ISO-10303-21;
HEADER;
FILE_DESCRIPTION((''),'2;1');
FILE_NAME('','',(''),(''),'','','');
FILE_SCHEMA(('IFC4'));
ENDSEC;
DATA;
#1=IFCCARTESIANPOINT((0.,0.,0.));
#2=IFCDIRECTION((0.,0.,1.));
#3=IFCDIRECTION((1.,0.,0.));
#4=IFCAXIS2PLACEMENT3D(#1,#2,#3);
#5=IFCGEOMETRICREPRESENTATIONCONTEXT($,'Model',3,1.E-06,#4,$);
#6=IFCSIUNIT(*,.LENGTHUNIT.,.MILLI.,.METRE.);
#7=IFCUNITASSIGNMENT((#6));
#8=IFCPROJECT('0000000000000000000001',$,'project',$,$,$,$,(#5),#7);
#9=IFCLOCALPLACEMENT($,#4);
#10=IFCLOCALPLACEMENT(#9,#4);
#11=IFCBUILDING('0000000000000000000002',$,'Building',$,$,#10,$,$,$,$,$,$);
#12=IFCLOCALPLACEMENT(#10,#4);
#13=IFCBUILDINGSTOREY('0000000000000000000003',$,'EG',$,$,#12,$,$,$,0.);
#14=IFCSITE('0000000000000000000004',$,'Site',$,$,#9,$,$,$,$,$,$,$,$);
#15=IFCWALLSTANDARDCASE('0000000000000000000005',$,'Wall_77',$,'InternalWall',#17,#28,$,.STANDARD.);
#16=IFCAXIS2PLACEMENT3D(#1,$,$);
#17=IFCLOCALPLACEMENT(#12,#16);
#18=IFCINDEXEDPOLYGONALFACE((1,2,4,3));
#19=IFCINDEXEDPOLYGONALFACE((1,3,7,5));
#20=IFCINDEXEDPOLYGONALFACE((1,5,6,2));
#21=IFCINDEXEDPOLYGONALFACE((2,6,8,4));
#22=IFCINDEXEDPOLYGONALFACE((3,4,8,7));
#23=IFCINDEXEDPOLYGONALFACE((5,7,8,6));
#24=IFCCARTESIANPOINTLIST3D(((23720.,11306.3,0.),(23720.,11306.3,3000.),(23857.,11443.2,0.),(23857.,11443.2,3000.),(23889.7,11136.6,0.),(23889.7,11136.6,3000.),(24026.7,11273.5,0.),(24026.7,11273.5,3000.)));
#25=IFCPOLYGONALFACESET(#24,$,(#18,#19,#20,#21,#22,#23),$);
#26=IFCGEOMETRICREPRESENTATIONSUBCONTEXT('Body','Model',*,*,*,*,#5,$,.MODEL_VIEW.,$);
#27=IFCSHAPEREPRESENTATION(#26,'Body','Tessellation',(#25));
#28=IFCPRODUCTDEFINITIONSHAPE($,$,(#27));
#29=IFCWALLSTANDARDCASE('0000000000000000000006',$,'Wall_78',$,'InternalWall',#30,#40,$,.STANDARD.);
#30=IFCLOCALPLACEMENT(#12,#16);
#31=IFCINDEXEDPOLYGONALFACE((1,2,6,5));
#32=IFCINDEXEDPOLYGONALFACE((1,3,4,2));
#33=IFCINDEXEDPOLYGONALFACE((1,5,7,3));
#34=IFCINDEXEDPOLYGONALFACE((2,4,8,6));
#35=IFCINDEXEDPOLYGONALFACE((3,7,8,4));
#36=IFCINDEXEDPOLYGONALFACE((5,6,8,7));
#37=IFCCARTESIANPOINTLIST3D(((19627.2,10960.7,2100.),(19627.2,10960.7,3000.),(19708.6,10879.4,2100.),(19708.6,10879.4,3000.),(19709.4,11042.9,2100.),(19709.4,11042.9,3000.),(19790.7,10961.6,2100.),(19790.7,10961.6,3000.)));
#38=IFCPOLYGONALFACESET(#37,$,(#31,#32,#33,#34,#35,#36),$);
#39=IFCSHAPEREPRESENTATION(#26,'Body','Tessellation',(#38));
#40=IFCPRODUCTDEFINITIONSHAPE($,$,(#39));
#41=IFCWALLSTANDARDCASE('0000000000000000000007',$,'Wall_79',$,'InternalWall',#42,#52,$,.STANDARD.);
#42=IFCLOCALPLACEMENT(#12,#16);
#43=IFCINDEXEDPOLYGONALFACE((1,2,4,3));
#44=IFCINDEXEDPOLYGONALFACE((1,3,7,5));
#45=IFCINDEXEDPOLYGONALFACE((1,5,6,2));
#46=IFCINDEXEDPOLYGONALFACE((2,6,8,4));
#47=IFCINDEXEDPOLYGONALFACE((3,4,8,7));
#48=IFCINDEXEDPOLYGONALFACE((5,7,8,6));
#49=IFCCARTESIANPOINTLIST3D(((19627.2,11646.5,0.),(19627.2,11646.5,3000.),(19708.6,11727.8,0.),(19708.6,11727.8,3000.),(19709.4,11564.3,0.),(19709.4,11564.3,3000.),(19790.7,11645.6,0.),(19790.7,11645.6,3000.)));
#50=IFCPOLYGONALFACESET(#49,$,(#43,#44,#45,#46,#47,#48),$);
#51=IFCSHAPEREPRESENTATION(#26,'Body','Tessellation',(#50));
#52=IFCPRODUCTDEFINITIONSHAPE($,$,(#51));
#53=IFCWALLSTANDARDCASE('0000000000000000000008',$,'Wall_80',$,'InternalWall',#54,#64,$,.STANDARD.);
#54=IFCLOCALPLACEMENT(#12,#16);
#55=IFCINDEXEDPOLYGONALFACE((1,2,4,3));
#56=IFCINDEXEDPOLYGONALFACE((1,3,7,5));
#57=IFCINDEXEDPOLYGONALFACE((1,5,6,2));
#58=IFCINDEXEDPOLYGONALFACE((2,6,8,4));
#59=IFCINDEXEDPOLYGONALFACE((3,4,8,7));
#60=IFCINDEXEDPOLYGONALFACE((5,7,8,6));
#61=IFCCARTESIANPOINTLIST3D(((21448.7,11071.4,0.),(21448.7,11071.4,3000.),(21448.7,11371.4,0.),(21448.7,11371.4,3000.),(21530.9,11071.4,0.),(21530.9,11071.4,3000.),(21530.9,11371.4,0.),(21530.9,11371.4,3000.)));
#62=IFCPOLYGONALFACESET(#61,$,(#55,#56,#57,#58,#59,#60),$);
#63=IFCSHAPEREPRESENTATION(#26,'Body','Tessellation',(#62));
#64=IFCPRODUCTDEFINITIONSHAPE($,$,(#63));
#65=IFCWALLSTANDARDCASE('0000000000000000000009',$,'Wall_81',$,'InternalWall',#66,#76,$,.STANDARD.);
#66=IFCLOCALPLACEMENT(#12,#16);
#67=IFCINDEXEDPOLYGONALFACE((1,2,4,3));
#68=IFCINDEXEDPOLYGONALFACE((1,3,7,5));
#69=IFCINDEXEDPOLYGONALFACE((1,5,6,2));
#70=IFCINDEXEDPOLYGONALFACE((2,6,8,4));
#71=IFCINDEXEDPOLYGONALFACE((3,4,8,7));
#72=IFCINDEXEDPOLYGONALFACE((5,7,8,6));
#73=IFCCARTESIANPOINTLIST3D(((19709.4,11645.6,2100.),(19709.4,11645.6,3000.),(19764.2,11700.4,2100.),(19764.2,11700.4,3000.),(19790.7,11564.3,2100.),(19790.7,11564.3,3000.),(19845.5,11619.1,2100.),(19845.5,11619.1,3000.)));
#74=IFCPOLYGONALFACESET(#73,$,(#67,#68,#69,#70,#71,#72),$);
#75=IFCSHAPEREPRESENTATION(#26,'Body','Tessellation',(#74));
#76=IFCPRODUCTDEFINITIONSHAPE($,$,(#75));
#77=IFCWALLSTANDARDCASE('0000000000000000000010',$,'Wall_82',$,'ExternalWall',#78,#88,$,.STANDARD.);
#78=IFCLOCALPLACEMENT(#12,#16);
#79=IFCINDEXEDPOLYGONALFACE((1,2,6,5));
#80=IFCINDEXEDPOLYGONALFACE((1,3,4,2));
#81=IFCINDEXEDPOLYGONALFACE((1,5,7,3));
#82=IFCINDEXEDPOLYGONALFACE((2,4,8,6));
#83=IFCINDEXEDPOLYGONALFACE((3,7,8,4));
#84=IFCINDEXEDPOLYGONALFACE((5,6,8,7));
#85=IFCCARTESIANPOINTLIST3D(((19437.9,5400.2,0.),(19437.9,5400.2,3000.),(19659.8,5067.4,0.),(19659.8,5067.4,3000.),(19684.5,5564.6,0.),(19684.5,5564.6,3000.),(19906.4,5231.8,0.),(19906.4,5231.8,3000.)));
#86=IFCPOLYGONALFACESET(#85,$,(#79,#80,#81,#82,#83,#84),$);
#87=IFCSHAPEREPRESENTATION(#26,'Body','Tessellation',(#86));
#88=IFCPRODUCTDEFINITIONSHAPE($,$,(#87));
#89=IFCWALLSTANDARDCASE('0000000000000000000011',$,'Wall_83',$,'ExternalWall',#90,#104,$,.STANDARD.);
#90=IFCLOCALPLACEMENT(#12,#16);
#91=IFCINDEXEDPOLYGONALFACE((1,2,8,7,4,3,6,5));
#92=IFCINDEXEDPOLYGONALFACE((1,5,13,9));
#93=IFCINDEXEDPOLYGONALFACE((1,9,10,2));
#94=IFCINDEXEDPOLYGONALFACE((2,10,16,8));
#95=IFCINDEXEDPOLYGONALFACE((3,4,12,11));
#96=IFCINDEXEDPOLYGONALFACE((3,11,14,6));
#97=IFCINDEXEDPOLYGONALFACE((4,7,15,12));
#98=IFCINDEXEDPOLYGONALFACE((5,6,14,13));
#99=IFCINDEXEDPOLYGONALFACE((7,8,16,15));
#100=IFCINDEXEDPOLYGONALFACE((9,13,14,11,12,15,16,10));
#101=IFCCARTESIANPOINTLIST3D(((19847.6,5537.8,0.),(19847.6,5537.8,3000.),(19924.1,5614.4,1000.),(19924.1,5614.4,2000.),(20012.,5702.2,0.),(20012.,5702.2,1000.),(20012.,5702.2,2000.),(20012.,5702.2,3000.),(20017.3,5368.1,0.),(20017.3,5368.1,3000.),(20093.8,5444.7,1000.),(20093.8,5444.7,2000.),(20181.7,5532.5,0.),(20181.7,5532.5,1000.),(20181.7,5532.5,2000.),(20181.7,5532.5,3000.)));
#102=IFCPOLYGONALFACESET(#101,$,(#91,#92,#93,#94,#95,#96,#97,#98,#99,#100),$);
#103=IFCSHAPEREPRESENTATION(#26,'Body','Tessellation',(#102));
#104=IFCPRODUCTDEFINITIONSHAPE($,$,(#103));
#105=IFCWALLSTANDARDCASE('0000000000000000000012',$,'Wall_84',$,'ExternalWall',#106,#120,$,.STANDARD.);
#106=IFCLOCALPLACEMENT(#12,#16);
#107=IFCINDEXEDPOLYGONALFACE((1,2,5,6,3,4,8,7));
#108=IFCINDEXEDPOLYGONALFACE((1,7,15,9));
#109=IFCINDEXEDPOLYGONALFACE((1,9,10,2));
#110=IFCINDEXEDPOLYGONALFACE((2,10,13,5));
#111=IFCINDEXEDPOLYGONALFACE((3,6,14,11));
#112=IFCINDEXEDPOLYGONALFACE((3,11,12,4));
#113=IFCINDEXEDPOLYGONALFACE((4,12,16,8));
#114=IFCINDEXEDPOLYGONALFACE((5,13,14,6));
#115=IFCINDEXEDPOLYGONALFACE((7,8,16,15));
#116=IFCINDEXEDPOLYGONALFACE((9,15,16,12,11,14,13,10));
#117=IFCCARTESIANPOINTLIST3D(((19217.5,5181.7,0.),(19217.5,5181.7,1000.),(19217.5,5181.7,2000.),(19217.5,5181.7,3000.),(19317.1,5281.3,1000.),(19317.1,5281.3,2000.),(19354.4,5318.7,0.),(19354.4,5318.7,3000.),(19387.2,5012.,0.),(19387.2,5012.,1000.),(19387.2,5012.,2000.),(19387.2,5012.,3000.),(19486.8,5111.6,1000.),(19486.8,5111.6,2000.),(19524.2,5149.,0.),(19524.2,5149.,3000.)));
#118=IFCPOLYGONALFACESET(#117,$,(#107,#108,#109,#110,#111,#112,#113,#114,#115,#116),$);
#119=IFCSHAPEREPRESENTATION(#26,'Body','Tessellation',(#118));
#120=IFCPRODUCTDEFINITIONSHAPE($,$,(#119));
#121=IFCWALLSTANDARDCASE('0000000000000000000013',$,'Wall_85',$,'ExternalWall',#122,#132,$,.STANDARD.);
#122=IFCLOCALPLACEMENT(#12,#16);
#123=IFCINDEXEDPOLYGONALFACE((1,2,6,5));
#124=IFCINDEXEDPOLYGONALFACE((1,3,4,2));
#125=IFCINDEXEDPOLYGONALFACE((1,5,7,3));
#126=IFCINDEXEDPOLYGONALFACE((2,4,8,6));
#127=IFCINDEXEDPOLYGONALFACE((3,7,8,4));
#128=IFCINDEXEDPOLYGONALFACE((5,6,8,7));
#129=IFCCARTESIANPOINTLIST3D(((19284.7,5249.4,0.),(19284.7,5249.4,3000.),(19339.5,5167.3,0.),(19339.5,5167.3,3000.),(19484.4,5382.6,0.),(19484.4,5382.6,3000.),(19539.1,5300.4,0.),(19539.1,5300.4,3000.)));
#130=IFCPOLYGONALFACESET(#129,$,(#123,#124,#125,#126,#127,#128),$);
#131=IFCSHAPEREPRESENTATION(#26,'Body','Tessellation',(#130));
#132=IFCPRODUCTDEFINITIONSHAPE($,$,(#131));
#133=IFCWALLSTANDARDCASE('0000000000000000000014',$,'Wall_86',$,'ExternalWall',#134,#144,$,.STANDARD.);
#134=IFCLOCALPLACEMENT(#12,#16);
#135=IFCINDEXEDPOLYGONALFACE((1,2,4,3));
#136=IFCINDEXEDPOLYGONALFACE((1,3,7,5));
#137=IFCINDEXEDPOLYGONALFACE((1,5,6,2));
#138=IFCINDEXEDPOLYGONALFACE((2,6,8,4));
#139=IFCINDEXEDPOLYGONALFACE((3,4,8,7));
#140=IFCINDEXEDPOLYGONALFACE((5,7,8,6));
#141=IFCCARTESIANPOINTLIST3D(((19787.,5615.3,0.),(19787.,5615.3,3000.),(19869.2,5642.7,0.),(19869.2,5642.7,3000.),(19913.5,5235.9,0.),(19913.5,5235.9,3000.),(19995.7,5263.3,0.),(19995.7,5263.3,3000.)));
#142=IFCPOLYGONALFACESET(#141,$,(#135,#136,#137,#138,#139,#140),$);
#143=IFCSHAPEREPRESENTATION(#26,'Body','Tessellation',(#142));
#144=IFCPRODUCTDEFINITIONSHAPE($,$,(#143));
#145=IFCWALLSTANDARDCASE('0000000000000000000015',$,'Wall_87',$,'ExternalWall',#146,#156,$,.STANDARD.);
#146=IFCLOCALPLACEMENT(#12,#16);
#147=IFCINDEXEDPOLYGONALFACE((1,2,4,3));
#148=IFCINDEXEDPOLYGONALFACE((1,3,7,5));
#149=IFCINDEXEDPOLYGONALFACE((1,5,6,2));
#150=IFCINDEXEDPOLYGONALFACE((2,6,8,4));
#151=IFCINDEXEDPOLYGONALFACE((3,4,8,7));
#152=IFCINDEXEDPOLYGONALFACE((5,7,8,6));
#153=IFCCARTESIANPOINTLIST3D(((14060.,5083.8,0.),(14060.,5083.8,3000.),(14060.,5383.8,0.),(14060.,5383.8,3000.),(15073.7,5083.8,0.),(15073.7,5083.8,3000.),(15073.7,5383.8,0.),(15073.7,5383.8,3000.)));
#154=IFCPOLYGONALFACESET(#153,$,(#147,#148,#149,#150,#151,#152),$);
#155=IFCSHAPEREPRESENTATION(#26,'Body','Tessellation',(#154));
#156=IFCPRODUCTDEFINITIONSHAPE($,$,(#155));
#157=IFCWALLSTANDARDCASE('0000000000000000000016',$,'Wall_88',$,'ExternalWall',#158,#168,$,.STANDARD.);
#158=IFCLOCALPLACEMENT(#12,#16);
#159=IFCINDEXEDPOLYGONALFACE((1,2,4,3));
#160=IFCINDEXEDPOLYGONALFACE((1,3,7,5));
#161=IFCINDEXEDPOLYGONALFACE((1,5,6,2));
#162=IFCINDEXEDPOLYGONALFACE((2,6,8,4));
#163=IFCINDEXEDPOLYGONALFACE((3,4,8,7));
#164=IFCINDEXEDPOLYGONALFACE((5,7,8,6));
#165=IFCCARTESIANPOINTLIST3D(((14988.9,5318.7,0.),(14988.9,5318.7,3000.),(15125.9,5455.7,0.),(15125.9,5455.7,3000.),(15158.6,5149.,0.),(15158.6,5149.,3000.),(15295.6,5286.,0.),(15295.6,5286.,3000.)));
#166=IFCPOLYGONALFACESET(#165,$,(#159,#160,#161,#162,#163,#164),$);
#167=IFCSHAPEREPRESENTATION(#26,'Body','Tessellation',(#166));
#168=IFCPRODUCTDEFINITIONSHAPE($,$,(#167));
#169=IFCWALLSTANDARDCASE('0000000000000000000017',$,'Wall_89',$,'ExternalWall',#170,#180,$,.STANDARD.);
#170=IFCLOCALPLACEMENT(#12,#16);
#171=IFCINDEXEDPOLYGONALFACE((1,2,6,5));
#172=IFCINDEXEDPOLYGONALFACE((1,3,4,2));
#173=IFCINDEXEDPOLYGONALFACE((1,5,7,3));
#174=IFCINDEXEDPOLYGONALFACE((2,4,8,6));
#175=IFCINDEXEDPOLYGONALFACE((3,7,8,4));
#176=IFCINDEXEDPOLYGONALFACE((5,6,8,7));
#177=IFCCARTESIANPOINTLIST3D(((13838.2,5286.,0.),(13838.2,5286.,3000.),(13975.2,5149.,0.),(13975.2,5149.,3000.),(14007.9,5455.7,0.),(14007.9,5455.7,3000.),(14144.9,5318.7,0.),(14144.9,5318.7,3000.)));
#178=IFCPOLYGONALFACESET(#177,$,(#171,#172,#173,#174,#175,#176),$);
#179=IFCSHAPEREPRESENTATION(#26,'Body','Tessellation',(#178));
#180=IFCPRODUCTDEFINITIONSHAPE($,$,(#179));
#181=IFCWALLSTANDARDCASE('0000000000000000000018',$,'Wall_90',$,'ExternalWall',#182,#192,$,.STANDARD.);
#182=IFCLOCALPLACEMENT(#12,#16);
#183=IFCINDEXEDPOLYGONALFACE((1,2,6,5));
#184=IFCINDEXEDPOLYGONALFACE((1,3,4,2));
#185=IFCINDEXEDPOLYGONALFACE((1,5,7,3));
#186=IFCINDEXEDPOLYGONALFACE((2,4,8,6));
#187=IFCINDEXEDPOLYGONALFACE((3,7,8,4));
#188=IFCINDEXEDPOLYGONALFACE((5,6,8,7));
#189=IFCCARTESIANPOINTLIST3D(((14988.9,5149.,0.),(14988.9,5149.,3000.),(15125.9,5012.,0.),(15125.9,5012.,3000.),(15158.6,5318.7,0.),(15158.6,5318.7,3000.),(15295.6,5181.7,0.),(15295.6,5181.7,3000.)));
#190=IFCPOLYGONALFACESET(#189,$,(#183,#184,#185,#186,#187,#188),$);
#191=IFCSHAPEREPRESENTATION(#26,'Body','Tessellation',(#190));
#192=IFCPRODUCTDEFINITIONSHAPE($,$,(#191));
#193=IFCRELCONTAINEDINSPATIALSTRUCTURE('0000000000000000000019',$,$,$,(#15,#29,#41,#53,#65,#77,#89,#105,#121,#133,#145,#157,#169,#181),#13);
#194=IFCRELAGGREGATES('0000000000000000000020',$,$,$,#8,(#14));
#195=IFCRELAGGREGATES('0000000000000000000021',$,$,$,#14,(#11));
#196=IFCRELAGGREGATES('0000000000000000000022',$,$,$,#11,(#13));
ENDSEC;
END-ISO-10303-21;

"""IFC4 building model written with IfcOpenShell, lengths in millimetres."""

from ifc_helpers import new_model, si_unit, frame, origin_with_axes, place, context, subcontext, project, spatial, rectangle, extrude, element, save


model = new_model("IFC4")

# Units and contexts
model_context = context("Model", 3, precision=1e-06, world=origin_with_axes())
body_context = subcontext(model_context, "Body", "Model", "MODEL_VIEW")
ifc_project = project(units=[si_unit("LENGTHUNIT", "METRE", prefix="MILLI")], contexts=[model_context])

# Site, building, storey
site_placement = place(None, origin_with_axes())
site = spatial("IfcSite", under=ifc_project, at=site_placement, Name="Site")
building_placement = place(site_placement, origin_with_axes())
building = spatial("IfcBuilding", under=site, at=building_placement, Name="Building")
storey_placement = place(building_placement, origin_with_axes())
storey = spatial("IfcBuildingStorey", under=building, at=storey_placement, Name="EG", Elevation=0.0)

# Wall
wall_1_placement = place(storey_placement, origin_with_axes())
element("IfcWallStandardCase", 1, at=wall_1_placement, inside=storey, Name="Wall_77", ObjectType="InternalWall", PredefinedType="STANDARD", context=body_context, shape_type="SweptSolid", body=[
    extrude(rectangle(XDim=193.7, YDim=240.0), frame((23873.4, 11289.9, 0.0), z_axis=(0.0, 0.0, 1.0), x_axis=(0.707107, 0.707107, 0.0)), (0.0, 0.0, 1.0), 3000.0),
])

# Wall, opening
wall_2_placement = place(storey_placement, origin_with_axes())
wall_2 = element("IfcWallStandardCase", 2, at=wall_2_placement, inside=storey, Name="Wall_78", ObjectType="InternalWall", PredefinedType="STANDARD", context=body_context, shape_type="SweptSolid", body=[
    extrude(rectangle(XDim=116.2, YDim=115.0), frame((19709.0, 10961.1, 0.0), z_axis=(0.0, 0.0, 1.0), x_axis=(-0.707107, -0.707107, 0.0)), (0.0, 0.0, 1.0), 3000.0),
])
opening_1_placement = place(wall_2_placement, origin_with_axes())
element("IfcOpeningElement", 3, at=opening_1_placement, inside=storey, cuts=wall_2, context=body_context, shape_type="SweptSolid", body=[
    extrude(rectangle(XDim=1514.1, YDim=115.0), frame((19689.2, 10941.4, 0.0), z_axis=(0.0, 0.0, 1.0), x_axis=(-0.707107, -0.707107, 0.0)), (0.0, 0.0, 1.0), 2100.0),
])

# Walls
wall_3_placement = place(storey_placement, origin_with_axes())
element("IfcWallStandardCase", 4, at=wall_3_placement, inside=storey, Name="Wall_79", ObjectType="InternalWall", PredefinedType="STANDARD", context=body_context, shape_type="SweptSolid", body=[
    extrude(rectangle(XDim=116.2, YDim=115.0), frame((19709.0, 11646.1, 0.0), z_axis=(0.0, 0.0, 1.0), x_axis=(-0.707107, 0.707107, 0.0)), (0.0, 0.0, 1.0), 3000.0),
])
wall_4_placement = place(storey_placement, origin_with_axes())
element("IfcWallStandardCase", 5, at=wall_4_placement, inside=storey, Name="Wall_80", ObjectType="InternalWall", PredefinedType="STANDARD", context=body_context, shape_type="SweptSolid", body=[
    extrude(rectangle(XDim=82.2, YDim=300.0), frame((21489.8, 11221.4, 0.0), z_axis=(0.0, 0.0, 1.0), x_axis=(-1.0, 0.0, 0.0)), (0.0, 0.0, 1.0), 3000.0),
])

# Wall, opening
wall_5_placement = place(storey_placement, origin_with_axes())
wall_5 = element("IfcWallStandardCase", 6, at=wall_5_placement, inside=storey, Name="Wall_81", ObjectType="InternalWall", PredefinedType="STANDARD", context=body_context, shape_type="SweptSolid", body=[
    extrude(rectangle(XDim=77.5, YDim=115.0), frame((19777.5, 11632.4, 0.0), z_axis=(0.0, 0.0, 1.0), x_axis=(0.707107, 0.707107, 0.0)), (0.0, 0.0, 1.0), 3000.0),
])
opening_2_placement = place(wall_5_placement, origin_with_axes())
element("IfcOpeningElement", 7, at=opening_2_placement, inside=storey, cuts=wall_5, context=body_context, shape_type="SweptSolid", body=[
    extrude(rectangle(XDim=904.8, YDim=115.0), frame((20060.3, 11915.1, 0.0), z_axis=(0.0, 0.0, 1.0), x_axis=(0.707107, 0.707107, 0.0)), (0.0, 0.0, 1.0), 2100.0),
])

# Wall
wall_6_placement = place(storey_placement, origin_with_axes())
element("IfcWallStandardCase", 8, at=wall_6_placement, inside=storey, Name="Wall_82", ObjectType="ExternalWall", PredefinedType="STANDARD", context=body_context, shape_type="SweptSolid", body=[
    extrude(rectangle(XDim=296.3, YDim=400.0), frame((19672.2, 5316.0, 0.0), z_axis=(0.0, 0.0, 1.0), x_axis=(-0.83205, -0.5547, 0.0)), (0.0, 0.0, 1.0), 3000.0),
])

# Walls, openings
wall_7_placement = place(storey_placement, origin_with_axes())
wall_7 = element("IfcWallStandardCase", 9, at=wall_7_placement, inside=storey, Name="Wall_83", ObjectType="ExternalWall", PredefinedType="STANDARD", context=body_context, shape_type="SweptSolid", body=[
    extrude(rectangle(XDim=232.5, YDim=240.0), frame((20014.6, 5535.2, 0.0), z_axis=(0.0, 0.0, 1.0), x_axis=(-0.707107, -0.707107, 0.0)), (0.0, 0.0, 1.0), 3000.0),
])
opening_3_placement = place(wall_7_placement, origin_with_axes())
element("IfcOpeningElement", 10, at=opening_3_placement, inside=storey, cuts=wall_7, context=body_context, shape_type="SweptSolid", body=[
    extrude(rectangle(XDim=2640.5, YDim=240.0), frame((20942.5, 6463.1, 1000.0), z_axis=(0.0, 0.0, 1.0), x_axis=(-0.707107, -0.707107, 0.0)), (0.0, 0.0, 1.0), 1000.0),
])
wall_8_placement = place(storey_placement, origin_with_axes())
wall_8 = element("IfcWallStandardCase", 11, at=wall_8_placement, inside=storey, Name="Wall_84", ObjectType="ExternalWall", PredefinedType="STANDARD", context=body_context, shape_type="SweptSolid", body=[
    extrude(rectangle(XDim=193.7, YDim=240.0), frame((19370.8, 5165.3, 0.0), z_axis=(0.0, 0.0, 1.0), x_axis=(-0.707107, -0.707107, 0.0)), (0.0, 0.0, 1.0), 3000.0),
])
opening_4_placement = place(wall_8_placement, origin_with_axes())
element("IfcOpeningElement", 12, at=opening_4_placement, inside=storey, cuts=wall_8, context=body_context, shape_type="SweptSolid", body=[
    extrude(rectangle(XDim=1071.0, YDim=240.0), frame((19023.3, 4817.9, 1000.0), z_axis=(0.0, 0.0, 1.0), x_axis=(-0.707107, -0.707107, 0.0)), (0.0, 0.0, 1.0), 1000.0),
])

# Walls
wall_9_placement = place(storey_placement, origin_with_axes())
element("IfcWallStandardCase", 13, at=wall_9_placement, inside=storey, Name="Wall_85", ObjectType="ExternalWall", PredefinedType="STANDARD", context=body_context, shape_type="SweptSolid", body=[
    extrude(rectangle(XDim=98.8, YDim=240.0), frame((19411.9, 5274.9, 0.0), z_axis=(0.0, 0.0, 1.0), x_axis=(-0.5547, 0.83205, 0.0)), (0.0, 0.0, 1.0), 3000.0),
])
wall_10_placement = place(storey_placement, origin_with_axes())
element("IfcWallStandardCase", 14, at=wall_10_placement, inside=storey, Name="Wall_86", ObjectType="ExternalWall", PredefinedType="STANDARD", context=body_context, shape_type="SweptSolid", body=[
    extrude(rectangle(XDim=86.6, YDim=400.0), frame((19891.4, 5439.3, 0.0), z_axis=(0.0, 0.0, 1.0), x_axis=(-0.948683, -0.316228, 0.0)), (0.0, 0.0, 1.0), 3000.0),
])
wall_11_placement = place(storey_placement, origin_with_axes())
element("IfcWallStandardCase", 15, at=wall_11_placement, inside=storey, Name="Wall_87", ObjectType="ExternalWall", PredefinedType="STANDARD", context=body_context, shape_type="SweptSolid", body=[
    extrude(rectangle(XDim=1013.7, YDim=300.0), frame((14566.9, 5233.8, 0.0), z_axis=(0.0, 0.0, 1.0), x_axis=(-1.0, 0.0, 0.0)), (0.0, 0.0, 1.0), 3000.0),
])
wall_12_placement = place(storey_placement, origin_with_axes())
element("IfcWallStandardCase", 16, at=wall_12_placement, inside=storey, Name="Wall_88", ObjectType="ExternalWall", PredefinedType="STANDARD", context=body_context, shape_type="SweptSolid", body=[
    extrude(rectangle(XDim=193.7, YDim=240.0), frame((15142.2, 5302.3, 0.0), z_axis=(0.0, 0.0, 1.0), x_axis=(0.707107, 0.707107, 0.0)), (0.0, 0.0, 1.0), 3000.0),
])
wall_13_placement = place(storey_placement, origin_with_axes())
element("IfcWallStandardCase", 17, at=wall_13_placement, inside=storey, Name="Wall_89", ObjectType="ExternalWall", PredefinedType="STANDARD", context=body_context, shape_type="SweptSolid", body=[
    extrude(rectangle(XDim=193.7, YDim=240.0), frame((13991.5, 5302.3, 0.0), z_axis=(0.0, 0.0, 1.0), x_axis=(-0.707107, 0.707107, 0.0)), (0.0, 0.0, 1.0), 3000.0),
])
wall_14_placement = place(storey_placement, origin_with_axes())
element("IfcWallStandardCase", 18, at=wall_14_placement, inside=storey, Name="Wall_90", ObjectType="ExternalWall", PredefinedType="STANDARD", context=body_context, shape_type="SweptSolid", body=[
    extrude(rectangle(XDim=193.7, YDim=240.0), frame((15142.2, 5165.3, 0.0), z_axis=(0.0, 0.0, 1.0), x_axis=(0.707107, -0.707107, 0.0)), (0.0, 0.0, 1.0), 3000.0),
])

save(model, "model.ifc")
